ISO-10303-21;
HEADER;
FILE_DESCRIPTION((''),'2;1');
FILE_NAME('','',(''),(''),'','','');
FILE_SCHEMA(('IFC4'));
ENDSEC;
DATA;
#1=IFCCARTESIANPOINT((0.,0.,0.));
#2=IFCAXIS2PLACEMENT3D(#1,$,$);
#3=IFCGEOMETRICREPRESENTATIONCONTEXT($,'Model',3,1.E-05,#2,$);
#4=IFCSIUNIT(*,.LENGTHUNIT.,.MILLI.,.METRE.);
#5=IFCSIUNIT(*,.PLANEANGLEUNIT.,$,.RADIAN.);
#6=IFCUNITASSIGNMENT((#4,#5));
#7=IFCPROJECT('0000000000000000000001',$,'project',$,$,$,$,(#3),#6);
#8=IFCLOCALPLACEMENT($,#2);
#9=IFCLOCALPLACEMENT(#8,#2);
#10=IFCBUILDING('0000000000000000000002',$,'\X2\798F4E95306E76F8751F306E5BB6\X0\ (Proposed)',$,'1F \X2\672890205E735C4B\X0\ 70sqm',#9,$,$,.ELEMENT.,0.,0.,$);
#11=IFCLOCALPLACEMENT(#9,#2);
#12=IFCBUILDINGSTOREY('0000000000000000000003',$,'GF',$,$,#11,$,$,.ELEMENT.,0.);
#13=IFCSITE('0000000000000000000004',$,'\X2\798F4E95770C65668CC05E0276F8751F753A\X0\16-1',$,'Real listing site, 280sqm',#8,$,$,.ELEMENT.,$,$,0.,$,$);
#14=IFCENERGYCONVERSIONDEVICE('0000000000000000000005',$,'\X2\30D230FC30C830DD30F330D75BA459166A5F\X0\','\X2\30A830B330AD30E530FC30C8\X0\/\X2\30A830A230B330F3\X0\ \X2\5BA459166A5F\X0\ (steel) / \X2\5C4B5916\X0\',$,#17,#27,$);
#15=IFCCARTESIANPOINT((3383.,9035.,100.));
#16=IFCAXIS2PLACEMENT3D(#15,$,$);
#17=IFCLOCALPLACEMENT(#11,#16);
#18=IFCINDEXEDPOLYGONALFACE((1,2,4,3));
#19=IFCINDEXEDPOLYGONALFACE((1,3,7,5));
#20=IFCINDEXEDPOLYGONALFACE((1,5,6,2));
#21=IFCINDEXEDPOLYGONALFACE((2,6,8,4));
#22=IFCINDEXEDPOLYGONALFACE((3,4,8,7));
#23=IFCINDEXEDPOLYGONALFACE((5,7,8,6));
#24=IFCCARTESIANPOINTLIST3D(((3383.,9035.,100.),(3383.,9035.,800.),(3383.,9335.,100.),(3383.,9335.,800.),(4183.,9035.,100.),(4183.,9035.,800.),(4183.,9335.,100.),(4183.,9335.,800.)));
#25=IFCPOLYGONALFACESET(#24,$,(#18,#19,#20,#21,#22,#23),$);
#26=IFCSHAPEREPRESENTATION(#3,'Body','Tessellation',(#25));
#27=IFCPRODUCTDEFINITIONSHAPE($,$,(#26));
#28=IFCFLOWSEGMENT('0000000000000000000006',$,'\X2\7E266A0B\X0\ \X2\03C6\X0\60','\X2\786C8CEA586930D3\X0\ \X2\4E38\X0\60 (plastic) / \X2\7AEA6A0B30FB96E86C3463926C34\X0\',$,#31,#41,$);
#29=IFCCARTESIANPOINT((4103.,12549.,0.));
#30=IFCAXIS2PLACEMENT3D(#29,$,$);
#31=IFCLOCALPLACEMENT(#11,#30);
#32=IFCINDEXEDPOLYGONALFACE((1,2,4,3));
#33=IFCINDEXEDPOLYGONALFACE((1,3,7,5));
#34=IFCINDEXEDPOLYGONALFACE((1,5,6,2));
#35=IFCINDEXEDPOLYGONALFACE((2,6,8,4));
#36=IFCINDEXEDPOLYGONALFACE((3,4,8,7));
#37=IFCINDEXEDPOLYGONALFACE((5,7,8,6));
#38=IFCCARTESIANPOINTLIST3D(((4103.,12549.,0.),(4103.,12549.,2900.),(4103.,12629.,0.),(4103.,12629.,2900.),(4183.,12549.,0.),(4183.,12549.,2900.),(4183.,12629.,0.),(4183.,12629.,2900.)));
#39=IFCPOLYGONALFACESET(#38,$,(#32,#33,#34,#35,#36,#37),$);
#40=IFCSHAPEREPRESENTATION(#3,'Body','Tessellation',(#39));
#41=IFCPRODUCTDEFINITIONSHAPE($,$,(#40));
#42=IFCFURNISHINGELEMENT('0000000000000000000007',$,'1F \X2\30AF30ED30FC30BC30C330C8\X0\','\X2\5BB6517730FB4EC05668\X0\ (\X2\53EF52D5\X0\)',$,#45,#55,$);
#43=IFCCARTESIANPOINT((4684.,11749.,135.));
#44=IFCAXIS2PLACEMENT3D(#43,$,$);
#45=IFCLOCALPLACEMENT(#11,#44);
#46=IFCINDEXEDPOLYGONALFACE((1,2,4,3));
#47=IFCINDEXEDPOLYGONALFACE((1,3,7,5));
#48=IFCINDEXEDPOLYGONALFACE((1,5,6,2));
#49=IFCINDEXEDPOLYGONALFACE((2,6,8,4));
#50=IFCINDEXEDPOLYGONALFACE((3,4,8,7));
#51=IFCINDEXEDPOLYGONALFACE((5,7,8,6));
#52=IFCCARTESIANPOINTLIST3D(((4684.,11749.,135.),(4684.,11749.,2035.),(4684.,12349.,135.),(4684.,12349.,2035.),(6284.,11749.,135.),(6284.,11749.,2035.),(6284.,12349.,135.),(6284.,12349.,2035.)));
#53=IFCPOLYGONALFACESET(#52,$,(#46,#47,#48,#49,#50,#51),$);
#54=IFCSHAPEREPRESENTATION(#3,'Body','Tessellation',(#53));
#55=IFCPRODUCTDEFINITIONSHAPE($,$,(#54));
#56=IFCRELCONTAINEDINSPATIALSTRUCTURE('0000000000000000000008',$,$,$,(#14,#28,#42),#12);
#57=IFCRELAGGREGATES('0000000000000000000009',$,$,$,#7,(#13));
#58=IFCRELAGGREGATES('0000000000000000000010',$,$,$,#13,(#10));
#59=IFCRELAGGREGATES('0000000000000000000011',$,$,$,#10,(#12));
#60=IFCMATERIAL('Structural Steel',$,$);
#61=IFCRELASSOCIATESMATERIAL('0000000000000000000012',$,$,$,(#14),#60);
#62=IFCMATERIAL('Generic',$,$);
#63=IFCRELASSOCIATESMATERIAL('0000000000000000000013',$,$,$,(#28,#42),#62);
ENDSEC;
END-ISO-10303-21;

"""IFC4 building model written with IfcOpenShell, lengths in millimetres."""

from ifc_helpers import new_model, si_unit, frame, frame_2d, origin, place, context, project, spatial, rectangle, extrude, material, element, save


model = new_model("IFC4")

# Units and contexts
model_context = context("Model", 3, precision=1e-05, world=origin())
ifc_project = project(units=[si_unit("LENGTHUNIT", "METRE", prefix="MILLI"), si_unit("PLANEANGLEUNIT", "RADIAN")], contexts=[model_context])

# Site, building, storey
site_placement = place(None, origin())
site = spatial("IfcSite", under=ifc_project, at=site_placement, Name="福井県敦賀市相生町16-1", ObjectType="Real listing site, 280sqm", CompositionType="ELEMENT", RefElevation=0.0)
building_placement = place(site_placement, origin())
building = spatial("IfcBuilding", under=site, at=building_placement, Name="福井の相生の家 (Proposed)", ObjectType="1F 木造平屋 70sqm", CompositionType="ELEMENT", ElevationOfRefHeight=0.0, ElevationOfTerrain=0.0)
storey_placement = place(building_placement, origin())
storey = spatial("IfcBuildingStorey", under=building, at=storey_placement, Name="GF", CompositionType="ELEMENT", Elevation=0.0)

# Shared definitions
ifc_material_1 = material(Name="Structural Steel")

# Shared definitions
ifc_material_2 = material(Name="Generic")

# Energy conversion device
energy_conversion_device_placement = place(storey_placement, frame((3383.0, 9035.0, 100.0)))
element("IfcEnergyConversionDevice", 1, at=energy_conversion_device_placement, inside=storey, material=ifc_material_1, Name="ヒートポンプ室外機", Description="エコキュート/エアコン 室外機 (steel) / 屋外", context=model_context, shape_type="SweptSolid", body=[
    extrude(rectangle(XDim=800.0, YDim=300.0, at=frame_2d((400.0, 150.0))), frame((3383.0, 9035.0, 100.0)), (0.0, 0.0, 1.0), 700.0),
])

# Flow segment
flow_segment_1_placement = place(storey_placement, frame((4103.0, 12549.0, 0.0)))
element("IfcFlowSegment", 2, at=flow_segment_1_placement, inside=storey, material=ifc_material_2, Name="縦樋 φ60", Description="硬質塩ビ 丸60 (plastic) / 竪樋・雨水排水", context=model_context, shape_type="SweptSolid", body=[
    extrude(rectangle(XDim=80.0, YDim=80.0, at=frame_2d((40.0, 40.0))), frame((4103.0, 12549.0, 0.0)), (0.0, 0.0, 1.0), 2900.0),
])

# Furnishing element
furnishing_placement = place(storey_placement, frame((4684.0, 11749.0, 135.0)))
element("IfcFurnishingElement", 3, at=furnishing_placement, inside=storey, material=ifc_material_2, Name="1F クローゼット", Description="家具・什器 (可動)", context=model_context, shape_type="SweptSolid", body=[
    extrude(rectangle(XDim=1600.0, YDim=600.0, at=frame_2d((800.0, 300.0))), frame((4684.0, 11749.0, 135.0)), (0.0, 0.0, 1.0), 1900.0),
])

save(model, "model.ifc")
